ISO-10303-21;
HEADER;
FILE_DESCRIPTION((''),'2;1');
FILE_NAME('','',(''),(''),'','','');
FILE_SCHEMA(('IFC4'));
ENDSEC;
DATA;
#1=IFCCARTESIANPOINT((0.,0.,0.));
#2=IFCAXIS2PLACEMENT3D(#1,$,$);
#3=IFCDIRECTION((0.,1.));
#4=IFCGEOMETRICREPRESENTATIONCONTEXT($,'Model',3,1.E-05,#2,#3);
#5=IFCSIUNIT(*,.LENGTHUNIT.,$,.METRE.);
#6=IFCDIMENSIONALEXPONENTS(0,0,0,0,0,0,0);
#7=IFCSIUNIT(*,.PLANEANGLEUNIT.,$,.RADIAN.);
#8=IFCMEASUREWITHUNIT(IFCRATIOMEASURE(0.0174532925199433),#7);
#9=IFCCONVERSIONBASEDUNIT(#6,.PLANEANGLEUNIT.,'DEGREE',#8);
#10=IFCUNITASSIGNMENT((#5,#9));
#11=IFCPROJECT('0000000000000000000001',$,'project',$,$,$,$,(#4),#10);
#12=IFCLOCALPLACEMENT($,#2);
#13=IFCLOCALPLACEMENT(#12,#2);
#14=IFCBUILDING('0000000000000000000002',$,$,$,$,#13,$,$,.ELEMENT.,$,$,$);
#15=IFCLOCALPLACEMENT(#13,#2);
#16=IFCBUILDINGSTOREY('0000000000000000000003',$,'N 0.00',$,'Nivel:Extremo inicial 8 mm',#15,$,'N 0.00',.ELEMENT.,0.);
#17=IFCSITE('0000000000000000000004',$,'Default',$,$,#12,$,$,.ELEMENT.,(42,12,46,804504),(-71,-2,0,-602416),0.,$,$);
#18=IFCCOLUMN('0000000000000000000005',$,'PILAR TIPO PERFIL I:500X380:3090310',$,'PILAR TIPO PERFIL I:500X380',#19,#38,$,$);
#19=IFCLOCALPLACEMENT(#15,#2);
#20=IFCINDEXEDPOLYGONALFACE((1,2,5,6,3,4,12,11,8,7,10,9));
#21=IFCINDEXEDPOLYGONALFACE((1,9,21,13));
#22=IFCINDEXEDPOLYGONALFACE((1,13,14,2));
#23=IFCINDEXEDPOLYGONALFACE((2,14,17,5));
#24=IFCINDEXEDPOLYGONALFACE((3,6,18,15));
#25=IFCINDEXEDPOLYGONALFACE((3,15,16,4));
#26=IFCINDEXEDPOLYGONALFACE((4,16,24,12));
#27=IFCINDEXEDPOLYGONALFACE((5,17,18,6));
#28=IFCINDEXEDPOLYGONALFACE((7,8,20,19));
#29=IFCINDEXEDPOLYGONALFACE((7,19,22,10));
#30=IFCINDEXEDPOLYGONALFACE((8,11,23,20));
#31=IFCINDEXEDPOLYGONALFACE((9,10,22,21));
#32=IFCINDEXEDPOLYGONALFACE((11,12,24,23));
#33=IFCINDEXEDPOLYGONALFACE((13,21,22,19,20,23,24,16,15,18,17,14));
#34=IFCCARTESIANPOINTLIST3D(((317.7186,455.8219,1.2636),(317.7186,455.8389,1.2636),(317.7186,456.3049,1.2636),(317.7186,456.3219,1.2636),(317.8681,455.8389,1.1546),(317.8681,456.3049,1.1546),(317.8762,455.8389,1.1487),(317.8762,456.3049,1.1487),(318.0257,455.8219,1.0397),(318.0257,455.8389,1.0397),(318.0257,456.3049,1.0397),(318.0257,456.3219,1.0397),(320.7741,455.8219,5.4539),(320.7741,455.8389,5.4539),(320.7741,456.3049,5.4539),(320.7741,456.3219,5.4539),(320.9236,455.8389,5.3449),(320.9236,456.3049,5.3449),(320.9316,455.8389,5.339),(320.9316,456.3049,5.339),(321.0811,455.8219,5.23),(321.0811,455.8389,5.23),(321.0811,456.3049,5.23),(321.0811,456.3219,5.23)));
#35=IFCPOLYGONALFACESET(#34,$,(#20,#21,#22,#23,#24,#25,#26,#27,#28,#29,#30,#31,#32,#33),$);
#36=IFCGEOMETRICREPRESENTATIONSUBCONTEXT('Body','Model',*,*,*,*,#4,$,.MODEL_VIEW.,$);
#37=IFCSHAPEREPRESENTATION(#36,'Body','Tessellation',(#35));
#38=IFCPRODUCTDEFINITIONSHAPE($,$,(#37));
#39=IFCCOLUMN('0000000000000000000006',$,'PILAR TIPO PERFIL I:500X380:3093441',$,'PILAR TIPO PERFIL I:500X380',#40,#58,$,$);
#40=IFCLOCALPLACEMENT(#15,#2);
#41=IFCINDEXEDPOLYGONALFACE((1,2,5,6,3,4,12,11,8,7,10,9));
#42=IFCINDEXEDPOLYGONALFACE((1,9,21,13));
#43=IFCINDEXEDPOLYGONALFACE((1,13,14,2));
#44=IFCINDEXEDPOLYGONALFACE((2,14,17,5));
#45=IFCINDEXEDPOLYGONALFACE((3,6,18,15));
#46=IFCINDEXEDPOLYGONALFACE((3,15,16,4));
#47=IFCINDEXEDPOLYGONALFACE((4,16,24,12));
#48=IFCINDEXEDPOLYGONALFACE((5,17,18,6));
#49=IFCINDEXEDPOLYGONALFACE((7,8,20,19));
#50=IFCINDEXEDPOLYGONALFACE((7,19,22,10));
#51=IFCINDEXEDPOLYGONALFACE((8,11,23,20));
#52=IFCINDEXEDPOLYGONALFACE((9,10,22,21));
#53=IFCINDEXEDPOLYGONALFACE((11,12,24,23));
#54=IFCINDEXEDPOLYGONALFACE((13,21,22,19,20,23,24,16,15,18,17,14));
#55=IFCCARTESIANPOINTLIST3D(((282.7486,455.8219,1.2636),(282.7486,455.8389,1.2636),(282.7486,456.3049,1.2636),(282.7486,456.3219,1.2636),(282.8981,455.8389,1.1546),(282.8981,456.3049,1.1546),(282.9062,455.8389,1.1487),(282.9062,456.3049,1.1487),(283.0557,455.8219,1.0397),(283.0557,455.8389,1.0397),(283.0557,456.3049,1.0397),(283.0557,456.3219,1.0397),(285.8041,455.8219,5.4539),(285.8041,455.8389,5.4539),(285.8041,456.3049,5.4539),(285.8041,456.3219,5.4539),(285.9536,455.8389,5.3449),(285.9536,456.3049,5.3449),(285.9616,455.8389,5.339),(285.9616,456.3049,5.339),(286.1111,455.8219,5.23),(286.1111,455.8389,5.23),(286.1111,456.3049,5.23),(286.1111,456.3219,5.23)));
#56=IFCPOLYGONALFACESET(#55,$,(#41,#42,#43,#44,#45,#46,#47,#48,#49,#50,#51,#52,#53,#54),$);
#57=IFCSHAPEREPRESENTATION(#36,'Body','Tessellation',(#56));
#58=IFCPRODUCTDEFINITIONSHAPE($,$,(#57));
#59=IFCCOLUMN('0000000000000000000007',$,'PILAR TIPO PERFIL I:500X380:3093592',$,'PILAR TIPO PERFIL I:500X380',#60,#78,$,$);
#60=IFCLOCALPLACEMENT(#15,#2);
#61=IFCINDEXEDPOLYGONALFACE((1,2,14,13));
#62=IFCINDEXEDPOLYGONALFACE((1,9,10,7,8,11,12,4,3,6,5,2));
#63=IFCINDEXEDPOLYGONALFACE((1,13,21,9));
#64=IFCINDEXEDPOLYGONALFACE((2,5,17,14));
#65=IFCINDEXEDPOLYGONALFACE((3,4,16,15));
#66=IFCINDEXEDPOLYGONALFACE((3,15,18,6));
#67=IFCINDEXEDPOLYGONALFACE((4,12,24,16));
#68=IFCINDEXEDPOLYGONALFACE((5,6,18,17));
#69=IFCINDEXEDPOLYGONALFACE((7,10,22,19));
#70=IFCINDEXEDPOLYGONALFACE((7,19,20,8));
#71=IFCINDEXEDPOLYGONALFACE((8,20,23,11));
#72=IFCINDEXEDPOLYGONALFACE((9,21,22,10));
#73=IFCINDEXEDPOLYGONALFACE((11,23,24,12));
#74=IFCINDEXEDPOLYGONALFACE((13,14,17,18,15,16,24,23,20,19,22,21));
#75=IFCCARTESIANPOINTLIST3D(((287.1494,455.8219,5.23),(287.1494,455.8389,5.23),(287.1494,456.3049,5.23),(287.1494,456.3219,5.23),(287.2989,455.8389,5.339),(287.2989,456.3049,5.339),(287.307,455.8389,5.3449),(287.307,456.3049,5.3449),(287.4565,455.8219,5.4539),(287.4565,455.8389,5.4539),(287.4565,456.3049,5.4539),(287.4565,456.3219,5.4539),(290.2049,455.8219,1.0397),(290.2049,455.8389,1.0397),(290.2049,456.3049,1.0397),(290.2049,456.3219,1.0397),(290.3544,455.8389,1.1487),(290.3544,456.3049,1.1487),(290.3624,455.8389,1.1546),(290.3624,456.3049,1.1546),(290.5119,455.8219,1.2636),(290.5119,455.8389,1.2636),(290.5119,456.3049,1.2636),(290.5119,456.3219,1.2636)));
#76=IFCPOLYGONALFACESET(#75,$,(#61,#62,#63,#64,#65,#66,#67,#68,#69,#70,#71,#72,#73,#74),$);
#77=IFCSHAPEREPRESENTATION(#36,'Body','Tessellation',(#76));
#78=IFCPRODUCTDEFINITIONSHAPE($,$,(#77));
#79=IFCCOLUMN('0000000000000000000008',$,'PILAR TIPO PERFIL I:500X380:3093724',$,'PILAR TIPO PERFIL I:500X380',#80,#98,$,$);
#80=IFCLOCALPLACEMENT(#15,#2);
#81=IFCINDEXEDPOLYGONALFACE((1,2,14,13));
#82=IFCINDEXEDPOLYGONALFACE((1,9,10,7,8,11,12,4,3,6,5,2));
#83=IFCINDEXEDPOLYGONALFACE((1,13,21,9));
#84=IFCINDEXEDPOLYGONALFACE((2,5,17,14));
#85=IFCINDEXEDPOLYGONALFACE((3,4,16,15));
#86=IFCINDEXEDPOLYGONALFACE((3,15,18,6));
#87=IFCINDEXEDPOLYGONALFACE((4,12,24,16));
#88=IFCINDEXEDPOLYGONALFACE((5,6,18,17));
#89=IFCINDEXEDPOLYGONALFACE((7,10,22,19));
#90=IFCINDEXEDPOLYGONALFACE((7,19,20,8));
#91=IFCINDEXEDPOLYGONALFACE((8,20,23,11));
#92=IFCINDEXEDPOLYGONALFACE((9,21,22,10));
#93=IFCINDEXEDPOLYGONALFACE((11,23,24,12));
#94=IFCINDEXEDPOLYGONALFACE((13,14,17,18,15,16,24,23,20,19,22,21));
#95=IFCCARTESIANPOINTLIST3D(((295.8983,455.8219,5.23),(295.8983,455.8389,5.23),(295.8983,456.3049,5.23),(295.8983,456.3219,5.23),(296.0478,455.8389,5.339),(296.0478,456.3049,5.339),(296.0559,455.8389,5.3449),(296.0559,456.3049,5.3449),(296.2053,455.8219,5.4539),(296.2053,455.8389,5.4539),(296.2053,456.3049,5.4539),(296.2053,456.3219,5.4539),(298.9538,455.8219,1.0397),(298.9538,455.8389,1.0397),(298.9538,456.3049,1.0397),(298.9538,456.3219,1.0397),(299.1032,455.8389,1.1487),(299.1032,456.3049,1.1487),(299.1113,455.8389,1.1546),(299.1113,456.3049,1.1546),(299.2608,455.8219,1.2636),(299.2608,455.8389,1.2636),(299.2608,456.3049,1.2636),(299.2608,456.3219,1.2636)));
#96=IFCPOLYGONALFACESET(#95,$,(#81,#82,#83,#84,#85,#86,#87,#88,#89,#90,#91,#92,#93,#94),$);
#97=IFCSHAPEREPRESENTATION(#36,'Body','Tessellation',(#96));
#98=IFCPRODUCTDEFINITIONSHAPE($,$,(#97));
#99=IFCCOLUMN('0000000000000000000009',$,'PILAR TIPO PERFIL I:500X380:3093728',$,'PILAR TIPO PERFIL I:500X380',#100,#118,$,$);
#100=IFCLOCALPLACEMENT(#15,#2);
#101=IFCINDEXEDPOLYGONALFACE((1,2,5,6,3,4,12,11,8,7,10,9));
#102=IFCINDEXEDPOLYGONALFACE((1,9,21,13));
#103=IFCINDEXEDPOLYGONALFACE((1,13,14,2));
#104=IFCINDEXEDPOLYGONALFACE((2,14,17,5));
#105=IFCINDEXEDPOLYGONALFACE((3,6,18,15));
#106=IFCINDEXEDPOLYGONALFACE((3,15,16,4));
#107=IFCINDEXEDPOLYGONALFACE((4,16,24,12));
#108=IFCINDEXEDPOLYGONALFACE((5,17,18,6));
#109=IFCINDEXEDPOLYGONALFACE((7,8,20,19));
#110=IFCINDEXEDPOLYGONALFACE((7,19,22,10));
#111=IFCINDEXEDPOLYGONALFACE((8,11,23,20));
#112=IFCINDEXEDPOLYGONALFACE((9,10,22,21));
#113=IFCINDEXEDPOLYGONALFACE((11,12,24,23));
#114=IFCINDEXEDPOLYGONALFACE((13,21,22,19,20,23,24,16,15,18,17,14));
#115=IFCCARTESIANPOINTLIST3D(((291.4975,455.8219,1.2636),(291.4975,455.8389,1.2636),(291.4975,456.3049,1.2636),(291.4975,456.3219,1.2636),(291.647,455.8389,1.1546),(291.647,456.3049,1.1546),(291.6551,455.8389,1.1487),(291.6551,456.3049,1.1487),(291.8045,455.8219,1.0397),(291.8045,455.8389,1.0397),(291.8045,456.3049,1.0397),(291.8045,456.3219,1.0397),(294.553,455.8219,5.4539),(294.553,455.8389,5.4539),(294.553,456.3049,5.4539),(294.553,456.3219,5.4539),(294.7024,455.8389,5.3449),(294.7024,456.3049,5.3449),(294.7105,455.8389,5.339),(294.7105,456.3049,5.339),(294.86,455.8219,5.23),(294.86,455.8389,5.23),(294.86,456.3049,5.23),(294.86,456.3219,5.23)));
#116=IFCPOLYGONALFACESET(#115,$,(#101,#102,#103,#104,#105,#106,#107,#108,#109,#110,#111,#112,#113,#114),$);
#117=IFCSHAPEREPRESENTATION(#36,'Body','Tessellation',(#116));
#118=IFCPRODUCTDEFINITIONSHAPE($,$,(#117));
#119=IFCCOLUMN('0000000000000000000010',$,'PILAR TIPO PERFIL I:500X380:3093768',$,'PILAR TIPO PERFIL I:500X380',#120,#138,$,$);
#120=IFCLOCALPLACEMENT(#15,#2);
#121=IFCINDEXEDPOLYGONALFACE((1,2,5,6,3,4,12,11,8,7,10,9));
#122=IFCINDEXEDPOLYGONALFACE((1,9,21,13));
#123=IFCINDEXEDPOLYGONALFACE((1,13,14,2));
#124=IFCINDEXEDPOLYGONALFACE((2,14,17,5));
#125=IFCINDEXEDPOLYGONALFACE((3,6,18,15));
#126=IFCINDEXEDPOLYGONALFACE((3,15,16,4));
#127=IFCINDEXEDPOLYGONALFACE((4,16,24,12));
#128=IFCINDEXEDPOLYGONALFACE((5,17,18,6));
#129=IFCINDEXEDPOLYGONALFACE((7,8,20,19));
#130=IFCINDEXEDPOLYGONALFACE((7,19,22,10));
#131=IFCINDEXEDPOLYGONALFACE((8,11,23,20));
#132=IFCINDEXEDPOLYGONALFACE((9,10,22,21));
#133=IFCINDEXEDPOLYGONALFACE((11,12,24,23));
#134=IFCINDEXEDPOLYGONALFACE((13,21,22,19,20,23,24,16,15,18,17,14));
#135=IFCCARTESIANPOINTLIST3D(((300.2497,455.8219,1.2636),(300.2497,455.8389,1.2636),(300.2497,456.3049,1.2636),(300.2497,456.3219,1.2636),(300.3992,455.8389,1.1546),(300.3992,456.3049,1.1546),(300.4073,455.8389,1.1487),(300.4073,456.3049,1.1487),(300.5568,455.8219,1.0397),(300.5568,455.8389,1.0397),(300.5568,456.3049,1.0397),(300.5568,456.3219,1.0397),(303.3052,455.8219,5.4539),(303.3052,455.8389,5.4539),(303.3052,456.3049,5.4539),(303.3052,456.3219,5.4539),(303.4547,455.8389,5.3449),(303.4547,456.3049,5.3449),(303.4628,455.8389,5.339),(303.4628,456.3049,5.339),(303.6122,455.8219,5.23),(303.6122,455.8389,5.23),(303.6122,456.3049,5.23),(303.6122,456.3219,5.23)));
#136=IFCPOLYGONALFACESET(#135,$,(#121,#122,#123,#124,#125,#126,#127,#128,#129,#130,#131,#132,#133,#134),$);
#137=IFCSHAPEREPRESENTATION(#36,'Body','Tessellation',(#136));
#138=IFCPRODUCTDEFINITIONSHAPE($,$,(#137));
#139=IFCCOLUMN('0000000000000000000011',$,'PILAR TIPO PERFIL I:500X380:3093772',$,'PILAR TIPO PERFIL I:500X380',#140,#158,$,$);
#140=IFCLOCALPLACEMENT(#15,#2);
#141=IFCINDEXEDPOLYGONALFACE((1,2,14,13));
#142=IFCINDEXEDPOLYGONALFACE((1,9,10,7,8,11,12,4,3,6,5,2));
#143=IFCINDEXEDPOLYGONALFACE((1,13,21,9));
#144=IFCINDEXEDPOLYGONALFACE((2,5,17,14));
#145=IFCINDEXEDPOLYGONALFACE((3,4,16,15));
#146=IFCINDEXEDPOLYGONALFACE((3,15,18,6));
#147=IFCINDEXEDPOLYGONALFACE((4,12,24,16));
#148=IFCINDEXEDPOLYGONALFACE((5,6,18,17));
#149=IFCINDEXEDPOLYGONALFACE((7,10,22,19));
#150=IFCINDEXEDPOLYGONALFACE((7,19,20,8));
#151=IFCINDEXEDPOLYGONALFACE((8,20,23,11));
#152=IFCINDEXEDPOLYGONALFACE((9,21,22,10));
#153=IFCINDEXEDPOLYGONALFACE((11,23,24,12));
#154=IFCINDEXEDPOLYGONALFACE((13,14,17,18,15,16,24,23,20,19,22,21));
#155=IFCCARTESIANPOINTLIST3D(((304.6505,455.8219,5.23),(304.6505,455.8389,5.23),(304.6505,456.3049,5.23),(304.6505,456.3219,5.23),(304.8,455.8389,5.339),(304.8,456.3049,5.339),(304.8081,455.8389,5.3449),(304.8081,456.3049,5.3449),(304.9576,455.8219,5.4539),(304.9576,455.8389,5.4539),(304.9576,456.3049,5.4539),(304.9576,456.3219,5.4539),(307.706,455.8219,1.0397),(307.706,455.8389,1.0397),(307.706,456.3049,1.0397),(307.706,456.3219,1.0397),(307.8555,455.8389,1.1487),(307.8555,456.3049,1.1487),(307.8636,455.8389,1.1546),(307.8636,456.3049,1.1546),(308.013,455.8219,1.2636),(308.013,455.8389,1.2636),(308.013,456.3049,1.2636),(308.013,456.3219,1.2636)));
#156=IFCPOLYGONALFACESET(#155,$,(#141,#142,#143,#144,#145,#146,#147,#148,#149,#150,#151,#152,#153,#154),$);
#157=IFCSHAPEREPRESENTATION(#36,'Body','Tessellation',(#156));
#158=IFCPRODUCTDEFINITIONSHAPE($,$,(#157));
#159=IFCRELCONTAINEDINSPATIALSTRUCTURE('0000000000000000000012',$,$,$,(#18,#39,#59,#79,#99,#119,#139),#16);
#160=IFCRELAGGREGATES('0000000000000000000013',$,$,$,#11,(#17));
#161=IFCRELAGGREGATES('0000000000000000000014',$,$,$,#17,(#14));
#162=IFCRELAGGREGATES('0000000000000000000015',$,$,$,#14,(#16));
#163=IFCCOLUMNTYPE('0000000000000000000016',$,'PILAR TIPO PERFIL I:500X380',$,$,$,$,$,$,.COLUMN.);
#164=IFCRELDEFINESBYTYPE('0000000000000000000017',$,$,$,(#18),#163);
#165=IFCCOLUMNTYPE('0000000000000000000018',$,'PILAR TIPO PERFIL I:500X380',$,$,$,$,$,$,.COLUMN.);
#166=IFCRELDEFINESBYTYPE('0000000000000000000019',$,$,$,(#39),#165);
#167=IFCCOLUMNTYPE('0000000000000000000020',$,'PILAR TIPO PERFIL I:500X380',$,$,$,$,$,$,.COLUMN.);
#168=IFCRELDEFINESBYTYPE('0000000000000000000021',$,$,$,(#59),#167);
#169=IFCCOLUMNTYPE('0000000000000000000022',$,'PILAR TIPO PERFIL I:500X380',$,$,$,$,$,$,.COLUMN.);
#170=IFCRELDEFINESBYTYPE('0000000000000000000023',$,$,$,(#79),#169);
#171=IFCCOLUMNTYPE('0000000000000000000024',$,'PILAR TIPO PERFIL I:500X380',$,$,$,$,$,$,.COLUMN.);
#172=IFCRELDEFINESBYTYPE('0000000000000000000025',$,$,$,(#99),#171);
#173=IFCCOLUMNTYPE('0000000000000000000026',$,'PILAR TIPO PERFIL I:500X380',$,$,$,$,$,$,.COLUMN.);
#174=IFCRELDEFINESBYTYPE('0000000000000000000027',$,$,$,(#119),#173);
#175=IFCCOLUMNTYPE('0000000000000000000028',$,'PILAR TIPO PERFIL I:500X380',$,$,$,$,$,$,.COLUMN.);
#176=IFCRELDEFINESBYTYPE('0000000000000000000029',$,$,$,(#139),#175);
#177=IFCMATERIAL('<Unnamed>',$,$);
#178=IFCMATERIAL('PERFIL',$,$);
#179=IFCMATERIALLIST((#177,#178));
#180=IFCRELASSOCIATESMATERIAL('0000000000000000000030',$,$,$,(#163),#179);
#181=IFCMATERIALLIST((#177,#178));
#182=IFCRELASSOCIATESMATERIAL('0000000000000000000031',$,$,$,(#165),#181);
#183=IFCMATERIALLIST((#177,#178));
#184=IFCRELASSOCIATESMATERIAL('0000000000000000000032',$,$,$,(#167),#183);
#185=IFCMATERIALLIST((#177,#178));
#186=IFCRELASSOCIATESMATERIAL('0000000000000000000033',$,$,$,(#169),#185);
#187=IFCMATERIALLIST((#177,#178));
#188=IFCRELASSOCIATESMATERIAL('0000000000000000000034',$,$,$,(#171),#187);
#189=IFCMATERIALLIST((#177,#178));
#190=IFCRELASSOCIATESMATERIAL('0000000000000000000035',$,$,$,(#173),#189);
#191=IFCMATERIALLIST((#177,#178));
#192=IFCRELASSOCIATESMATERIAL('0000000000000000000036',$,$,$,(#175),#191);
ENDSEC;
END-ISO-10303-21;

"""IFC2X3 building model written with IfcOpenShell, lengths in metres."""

from ifc_helpers import new_model, entity, si_unit, converted_unit, direction, frame, origin, place, context, subcontext, project, spatial, polyline, outline, extrude, source, transform, mapped, material, material_list, type_object, type_shapes, element, save


model = new_model("IFC2X3")

# Units and contexts
model_context = context("Model", 3, precision=1e-05, world=origin(), true_north=direction((0.0, 1.0)))
body_context = subcontext(model_context, "Body", "Model", "MODEL_VIEW")
ifc_project = project(units=[si_unit("LENGTHUNIT", "METRE"), converted_unit("PLANEANGLEUNIT", "DEGREE", entity("IfcRatioMeasure", 0.0174532925199433), si_unit("PLANEANGLEUNIT", "RADIAN"), dimensions=[0, 0, 0, 0, 0, 0, 0])], contexts=[model_context])

# Site, building, storey
site_placement = place(None, origin())
site = spatial("IfcSite", under=ifc_project, at=site_placement, Name="Default", CompositionType="ELEMENT", RefLatitude=(42, 12, 46, 804504), RefLongitude=(-71, -2, 0, -602416), RefElevation=0.0)
building_placement = place(site_placement, origin())
building = spatial("IfcBuilding", under=site, at=building_placement, CompositionType="ELEMENT")
storey_placement = place(building_placement, origin())
storey = spatial("IfcBuildingStorey", under=building, at=storey_placement, Name="N 0.00", ObjectType="Nivel:Extremo inicial 8 mm", LongName="N 0.00", CompositionType="ELEMENT", Elevation=0.0)

# Columns
ifc_material_1 = material(Name="<Unnamed>")
ifc_material_2 = material(Name="PERFIL")
ifc_material_list_1 = material_list([ifc_material_1, ifc_material_2])
column_type_1 = type_object("IfcColumnType", Name="PILAR TIPO PERFIL I:500X380", PredefinedType="COLUMN", material=ifc_material_list_1)
shared_shape_1 = source(origin(), body_context, "Body", "SweptSolid", [
    extrude(outline(polyline([(0.233, -0.19), (0.25, -0.19), (0.25, 0.19), (0.233, 0.19), (0.233, 0.005), (-0.233, 0.005), (-0.233, 0.19), (-0.25, 0.19), (-0.25, -0.19), (-0.233, -0.19), (-0.233, -0.005), (0.233, -0.005), (0.233, -0.19)])), frame((317.8722, 456.0719, 1.1516), z_axis=(0.589174, 0.0, 0.808006), x_axis=(0.0, -1.0, 0.0)), (0.0, 0.0, 1.0), 5.186),
])
type_shapes(column_type_1, [shared_shape_1])
column_1_placement = place(storey_placement, origin())
element("IfcColumn", 1, at=column_1_placement, inside=storey, type_object=column_type_1, Name="PILAR TIPO PERFIL I:500X380:3090310", ObjectType="PILAR TIPO PERFIL I:500X380", context=body_context, shape_type="MappedRepresentation", body=[
    mapped(shared_shape_1, transform((0.0, 0.0, 0.0), scale=1.0)),
])
ifc_material_list_2 = material_list([ifc_material_1, ifc_material_2])
column_type_2 = type_object("IfcColumnType", Name="PILAR TIPO PERFIL I:500X380", PredefinedType="COLUMN", material=ifc_material_list_2)
shared_shape_2 = source(origin(), body_context, "Body", "SweptSolid", [
    extrude(outline(polyline([(0.233, -0.19), (0.25, -0.19), (0.25, 0.19), (0.233, 0.19), (0.233, 0.005), (-0.233, 0.005), (-0.233, 0.19), (-0.25, 0.19), (-0.25, -0.19), (-0.233, -0.19), (-0.233, -0.005), (0.233, -0.005), (0.233, -0.19)])), frame((282.9021, 456.0719, 1.1516), z_axis=(0.589174, 0.0, 0.808006), x_axis=(0.0, -1.0, 0.0)), (0.0, 0.0, 1.0), 5.186),
])
type_shapes(column_type_2, [shared_shape_2])
column_2_placement = place(storey_placement, origin())
element("IfcColumn", 2, at=column_2_placement, inside=storey, type_object=column_type_2, Name="PILAR TIPO PERFIL I:500X380:3093441", ObjectType="PILAR TIPO PERFIL I:500X380", context=body_context, shape_type="MappedRepresentation", body=[
    mapped(shared_shape_2, transform((0.0, 0.0, 0.0), scale=1.0)),
])
ifc_material_list_3 = material_list([ifc_material_1, ifc_material_2])
column_type_3 = type_object("IfcColumnType", Name="PILAR TIPO PERFIL I:500X380", PredefinedType="COLUMN", material=ifc_material_list_3)
shared_shape_3 = source(origin(), body_context, "Body", "SweptSolid", [
    extrude(outline(polyline([(0.233, -0.19), (0.25, -0.19), (0.25, 0.19), (0.233, 0.19), (0.233, 0.005), (-0.233, 0.005), (-0.233, 0.19), (-0.25, 0.19), (-0.25, -0.19), (-0.233, -0.19), (-0.233, -0.005), (0.233, -0.005), (0.233, -0.19)])), frame((290.3584, 456.0719, 1.1516), z_axis=(-0.589174, 0.0, 0.808006), x_axis=(0.0, -1.0, 0.0)), (0.0, 0.0, 1.0), 5.186),
])
type_shapes(column_type_3, [shared_shape_3])
column_3_placement = place(storey_placement, origin())
element("IfcColumn", 3, at=column_3_placement, inside=storey, type_object=column_type_3, Name="PILAR TIPO PERFIL I:500X380:3093592", ObjectType="PILAR TIPO PERFIL I:500X380", context=body_context, shape_type="MappedRepresentation", body=[
    mapped(shared_shape_3, transform((0.0, 0.0, 0.0), scale=1.0)),
])
ifc_material_list_4 = material_list([ifc_material_1, ifc_material_2])
column_type_4 = type_object("IfcColumnType", Name="PILAR TIPO PERFIL I:500X380", PredefinedType="COLUMN", material=ifc_material_list_4)
shared_shape_4 = source(origin(), body_context, "Body", "SweptSolid", [
    extrude(outline(polyline([(0.233, -0.19), (0.25, -0.19), (0.25, 0.19), (0.233, 0.19), (0.233, 0.005), (-0.233, 0.005), (-0.233, 0.19), (-0.25, 0.19), (-0.25, -0.19), (-0.233, -0.19), (-0.233, -0.005), (0.233, -0.005), (0.233, -0.19)])), frame((299.1073, 456.0719, 1.1516), z_axis=(-0.589174, 0.0, 0.808006), x_axis=(0.0, -1.0, 0.0)), (0.0, 0.0, 1.0), 5.186),
])
type_shapes(column_type_4, [shared_shape_4])
column_4_placement = place(storey_placement, origin())
element("IfcColumn", 4, at=column_4_placement, inside=storey, type_object=column_type_4, Name="PILAR TIPO PERFIL I:500X380:3093724", ObjectType="PILAR TIPO PERFIL I:500X380", context=body_context, shape_type="MappedRepresentation", body=[
    mapped(shared_shape_4, transform((0.0, 0.0, 0.0), scale=1.0)),
])
ifc_material_list_5 = material_list([ifc_material_1, ifc_material_2])
column_type_5 = type_object("IfcColumnType", Name="PILAR TIPO PERFIL I:500X380", PredefinedType="COLUMN", material=ifc_material_list_5)
shared_shape_5 = source(origin(), body_context, "Body", "SweptSolid", [
    extrude(outline(polyline([(0.233, -0.19), (0.25, -0.19), (0.25, 0.19), (0.233, 0.19), (0.233, 0.005), (-0.233, 0.005), (-0.233, 0.19), (-0.25, 0.19), (-0.25, -0.19), (-0.233, -0.19), (-0.233, -0.005), (0.233, -0.005), (0.233, -0.19)])), frame((291.651, 456.0719, 1.1516), z_axis=(0.589174, 0.0, 0.808006), x_axis=(0.0, -1.0, 0.0)), (0.0, 0.0, 1.0), 5.186),
])
type_shapes(column_type_5, [shared_shape_5])
column_5_placement = place(storey_placement, origin())
element("IfcColumn", 5, at=column_5_placement, inside=storey, type_object=column_type_5, Name="PILAR TIPO PERFIL I:500X380:3093728", ObjectType="PILAR TIPO PERFIL I:500X380", context=body_context, shape_type="MappedRepresentation", body=[
    mapped(shared_shape_5, transform((0.0, 0.0, 0.0), scale=1.0)),
])
ifc_material_list_6 = material_list([ifc_material_1, ifc_material_2])
column_type_6 = type_object("IfcColumnType", Name="PILAR TIPO PERFIL I:500X380", PredefinedType="COLUMN", material=ifc_material_list_6)
shared_shape_6 = source(origin(), body_context, "Body", "SweptSolid", [
    extrude(outline(polyline([(0.233, -0.19), (0.25, -0.19), (0.25, 0.19), (0.233, 0.19), (0.233, 0.005), (-0.233, 0.005), (-0.233, 0.19), (-0.25, 0.19), (-0.25, -0.19), (-0.233, -0.19), (-0.233, -0.005), (0.233, -0.005), (0.233, -0.19)])), frame((300.4033, 456.0719, 1.1516), z_axis=(0.589174, 0.0, 0.808006), x_axis=(0.0, -1.0, 0.0)), (0.0, 0.0, 1.0), 5.186),
])
type_shapes(column_type_6, [shared_shape_6])
column_6_placement = place(storey_placement, origin())
element("IfcColumn", 6, at=column_6_placement, inside=storey, type_object=column_type_6, Name="PILAR TIPO PERFIL I:500X380:3093768", ObjectType="PILAR TIPO PERFIL I:500X380", context=body_context, shape_type="MappedRepresentation", body=[
    mapped(shared_shape_6, transform((0.0, 0.0, 0.0), scale=1.0)),
])
ifc_material_list_7 = material_list([ifc_material_1, ifc_material_2])
column_type_7 = type_object("IfcColumnType", Name="PILAR TIPO PERFIL I:500X380", PredefinedType="COLUMN", material=ifc_material_list_7)
shared_shape_7 = source(origin(), body_context, "Body", "SweptSolid", [
    extrude(outline(polyline([(0.233, -0.19), (0.25, -0.19), (0.25, 0.19), (0.233, 0.19), (0.233, 0.005), (-0.233, 0.005), (-0.233, 0.19), (-0.25, 0.19), (-0.25, -0.19), (-0.233, -0.19), (-0.233, -0.005), (0.233, -0.005), (0.233, -0.19)])), frame((307.8595, 456.0719, 1.1516), z_axis=(-0.589174, 0.0, 0.808006), x_axis=(0.0, -1.0, 0.0)), (0.0, 0.0, 1.0), 5.186),
])
type_shapes(column_type_7, [shared_shape_7])
column_7_placement = place(storey_placement, origin())
element("IfcColumn", 7, at=column_7_placement, inside=storey, type_object=column_type_7, Name="PILAR TIPO PERFIL I:500X380:3093772", ObjectType="PILAR TIPO PERFIL I:500X380", context=body_context, shape_type="MappedRepresentation", body=[
    mapped(shared_shape_7, transform((0.0, 0.0, 0.0), scale=1.0)),
])

save(model, "model.ifc")
